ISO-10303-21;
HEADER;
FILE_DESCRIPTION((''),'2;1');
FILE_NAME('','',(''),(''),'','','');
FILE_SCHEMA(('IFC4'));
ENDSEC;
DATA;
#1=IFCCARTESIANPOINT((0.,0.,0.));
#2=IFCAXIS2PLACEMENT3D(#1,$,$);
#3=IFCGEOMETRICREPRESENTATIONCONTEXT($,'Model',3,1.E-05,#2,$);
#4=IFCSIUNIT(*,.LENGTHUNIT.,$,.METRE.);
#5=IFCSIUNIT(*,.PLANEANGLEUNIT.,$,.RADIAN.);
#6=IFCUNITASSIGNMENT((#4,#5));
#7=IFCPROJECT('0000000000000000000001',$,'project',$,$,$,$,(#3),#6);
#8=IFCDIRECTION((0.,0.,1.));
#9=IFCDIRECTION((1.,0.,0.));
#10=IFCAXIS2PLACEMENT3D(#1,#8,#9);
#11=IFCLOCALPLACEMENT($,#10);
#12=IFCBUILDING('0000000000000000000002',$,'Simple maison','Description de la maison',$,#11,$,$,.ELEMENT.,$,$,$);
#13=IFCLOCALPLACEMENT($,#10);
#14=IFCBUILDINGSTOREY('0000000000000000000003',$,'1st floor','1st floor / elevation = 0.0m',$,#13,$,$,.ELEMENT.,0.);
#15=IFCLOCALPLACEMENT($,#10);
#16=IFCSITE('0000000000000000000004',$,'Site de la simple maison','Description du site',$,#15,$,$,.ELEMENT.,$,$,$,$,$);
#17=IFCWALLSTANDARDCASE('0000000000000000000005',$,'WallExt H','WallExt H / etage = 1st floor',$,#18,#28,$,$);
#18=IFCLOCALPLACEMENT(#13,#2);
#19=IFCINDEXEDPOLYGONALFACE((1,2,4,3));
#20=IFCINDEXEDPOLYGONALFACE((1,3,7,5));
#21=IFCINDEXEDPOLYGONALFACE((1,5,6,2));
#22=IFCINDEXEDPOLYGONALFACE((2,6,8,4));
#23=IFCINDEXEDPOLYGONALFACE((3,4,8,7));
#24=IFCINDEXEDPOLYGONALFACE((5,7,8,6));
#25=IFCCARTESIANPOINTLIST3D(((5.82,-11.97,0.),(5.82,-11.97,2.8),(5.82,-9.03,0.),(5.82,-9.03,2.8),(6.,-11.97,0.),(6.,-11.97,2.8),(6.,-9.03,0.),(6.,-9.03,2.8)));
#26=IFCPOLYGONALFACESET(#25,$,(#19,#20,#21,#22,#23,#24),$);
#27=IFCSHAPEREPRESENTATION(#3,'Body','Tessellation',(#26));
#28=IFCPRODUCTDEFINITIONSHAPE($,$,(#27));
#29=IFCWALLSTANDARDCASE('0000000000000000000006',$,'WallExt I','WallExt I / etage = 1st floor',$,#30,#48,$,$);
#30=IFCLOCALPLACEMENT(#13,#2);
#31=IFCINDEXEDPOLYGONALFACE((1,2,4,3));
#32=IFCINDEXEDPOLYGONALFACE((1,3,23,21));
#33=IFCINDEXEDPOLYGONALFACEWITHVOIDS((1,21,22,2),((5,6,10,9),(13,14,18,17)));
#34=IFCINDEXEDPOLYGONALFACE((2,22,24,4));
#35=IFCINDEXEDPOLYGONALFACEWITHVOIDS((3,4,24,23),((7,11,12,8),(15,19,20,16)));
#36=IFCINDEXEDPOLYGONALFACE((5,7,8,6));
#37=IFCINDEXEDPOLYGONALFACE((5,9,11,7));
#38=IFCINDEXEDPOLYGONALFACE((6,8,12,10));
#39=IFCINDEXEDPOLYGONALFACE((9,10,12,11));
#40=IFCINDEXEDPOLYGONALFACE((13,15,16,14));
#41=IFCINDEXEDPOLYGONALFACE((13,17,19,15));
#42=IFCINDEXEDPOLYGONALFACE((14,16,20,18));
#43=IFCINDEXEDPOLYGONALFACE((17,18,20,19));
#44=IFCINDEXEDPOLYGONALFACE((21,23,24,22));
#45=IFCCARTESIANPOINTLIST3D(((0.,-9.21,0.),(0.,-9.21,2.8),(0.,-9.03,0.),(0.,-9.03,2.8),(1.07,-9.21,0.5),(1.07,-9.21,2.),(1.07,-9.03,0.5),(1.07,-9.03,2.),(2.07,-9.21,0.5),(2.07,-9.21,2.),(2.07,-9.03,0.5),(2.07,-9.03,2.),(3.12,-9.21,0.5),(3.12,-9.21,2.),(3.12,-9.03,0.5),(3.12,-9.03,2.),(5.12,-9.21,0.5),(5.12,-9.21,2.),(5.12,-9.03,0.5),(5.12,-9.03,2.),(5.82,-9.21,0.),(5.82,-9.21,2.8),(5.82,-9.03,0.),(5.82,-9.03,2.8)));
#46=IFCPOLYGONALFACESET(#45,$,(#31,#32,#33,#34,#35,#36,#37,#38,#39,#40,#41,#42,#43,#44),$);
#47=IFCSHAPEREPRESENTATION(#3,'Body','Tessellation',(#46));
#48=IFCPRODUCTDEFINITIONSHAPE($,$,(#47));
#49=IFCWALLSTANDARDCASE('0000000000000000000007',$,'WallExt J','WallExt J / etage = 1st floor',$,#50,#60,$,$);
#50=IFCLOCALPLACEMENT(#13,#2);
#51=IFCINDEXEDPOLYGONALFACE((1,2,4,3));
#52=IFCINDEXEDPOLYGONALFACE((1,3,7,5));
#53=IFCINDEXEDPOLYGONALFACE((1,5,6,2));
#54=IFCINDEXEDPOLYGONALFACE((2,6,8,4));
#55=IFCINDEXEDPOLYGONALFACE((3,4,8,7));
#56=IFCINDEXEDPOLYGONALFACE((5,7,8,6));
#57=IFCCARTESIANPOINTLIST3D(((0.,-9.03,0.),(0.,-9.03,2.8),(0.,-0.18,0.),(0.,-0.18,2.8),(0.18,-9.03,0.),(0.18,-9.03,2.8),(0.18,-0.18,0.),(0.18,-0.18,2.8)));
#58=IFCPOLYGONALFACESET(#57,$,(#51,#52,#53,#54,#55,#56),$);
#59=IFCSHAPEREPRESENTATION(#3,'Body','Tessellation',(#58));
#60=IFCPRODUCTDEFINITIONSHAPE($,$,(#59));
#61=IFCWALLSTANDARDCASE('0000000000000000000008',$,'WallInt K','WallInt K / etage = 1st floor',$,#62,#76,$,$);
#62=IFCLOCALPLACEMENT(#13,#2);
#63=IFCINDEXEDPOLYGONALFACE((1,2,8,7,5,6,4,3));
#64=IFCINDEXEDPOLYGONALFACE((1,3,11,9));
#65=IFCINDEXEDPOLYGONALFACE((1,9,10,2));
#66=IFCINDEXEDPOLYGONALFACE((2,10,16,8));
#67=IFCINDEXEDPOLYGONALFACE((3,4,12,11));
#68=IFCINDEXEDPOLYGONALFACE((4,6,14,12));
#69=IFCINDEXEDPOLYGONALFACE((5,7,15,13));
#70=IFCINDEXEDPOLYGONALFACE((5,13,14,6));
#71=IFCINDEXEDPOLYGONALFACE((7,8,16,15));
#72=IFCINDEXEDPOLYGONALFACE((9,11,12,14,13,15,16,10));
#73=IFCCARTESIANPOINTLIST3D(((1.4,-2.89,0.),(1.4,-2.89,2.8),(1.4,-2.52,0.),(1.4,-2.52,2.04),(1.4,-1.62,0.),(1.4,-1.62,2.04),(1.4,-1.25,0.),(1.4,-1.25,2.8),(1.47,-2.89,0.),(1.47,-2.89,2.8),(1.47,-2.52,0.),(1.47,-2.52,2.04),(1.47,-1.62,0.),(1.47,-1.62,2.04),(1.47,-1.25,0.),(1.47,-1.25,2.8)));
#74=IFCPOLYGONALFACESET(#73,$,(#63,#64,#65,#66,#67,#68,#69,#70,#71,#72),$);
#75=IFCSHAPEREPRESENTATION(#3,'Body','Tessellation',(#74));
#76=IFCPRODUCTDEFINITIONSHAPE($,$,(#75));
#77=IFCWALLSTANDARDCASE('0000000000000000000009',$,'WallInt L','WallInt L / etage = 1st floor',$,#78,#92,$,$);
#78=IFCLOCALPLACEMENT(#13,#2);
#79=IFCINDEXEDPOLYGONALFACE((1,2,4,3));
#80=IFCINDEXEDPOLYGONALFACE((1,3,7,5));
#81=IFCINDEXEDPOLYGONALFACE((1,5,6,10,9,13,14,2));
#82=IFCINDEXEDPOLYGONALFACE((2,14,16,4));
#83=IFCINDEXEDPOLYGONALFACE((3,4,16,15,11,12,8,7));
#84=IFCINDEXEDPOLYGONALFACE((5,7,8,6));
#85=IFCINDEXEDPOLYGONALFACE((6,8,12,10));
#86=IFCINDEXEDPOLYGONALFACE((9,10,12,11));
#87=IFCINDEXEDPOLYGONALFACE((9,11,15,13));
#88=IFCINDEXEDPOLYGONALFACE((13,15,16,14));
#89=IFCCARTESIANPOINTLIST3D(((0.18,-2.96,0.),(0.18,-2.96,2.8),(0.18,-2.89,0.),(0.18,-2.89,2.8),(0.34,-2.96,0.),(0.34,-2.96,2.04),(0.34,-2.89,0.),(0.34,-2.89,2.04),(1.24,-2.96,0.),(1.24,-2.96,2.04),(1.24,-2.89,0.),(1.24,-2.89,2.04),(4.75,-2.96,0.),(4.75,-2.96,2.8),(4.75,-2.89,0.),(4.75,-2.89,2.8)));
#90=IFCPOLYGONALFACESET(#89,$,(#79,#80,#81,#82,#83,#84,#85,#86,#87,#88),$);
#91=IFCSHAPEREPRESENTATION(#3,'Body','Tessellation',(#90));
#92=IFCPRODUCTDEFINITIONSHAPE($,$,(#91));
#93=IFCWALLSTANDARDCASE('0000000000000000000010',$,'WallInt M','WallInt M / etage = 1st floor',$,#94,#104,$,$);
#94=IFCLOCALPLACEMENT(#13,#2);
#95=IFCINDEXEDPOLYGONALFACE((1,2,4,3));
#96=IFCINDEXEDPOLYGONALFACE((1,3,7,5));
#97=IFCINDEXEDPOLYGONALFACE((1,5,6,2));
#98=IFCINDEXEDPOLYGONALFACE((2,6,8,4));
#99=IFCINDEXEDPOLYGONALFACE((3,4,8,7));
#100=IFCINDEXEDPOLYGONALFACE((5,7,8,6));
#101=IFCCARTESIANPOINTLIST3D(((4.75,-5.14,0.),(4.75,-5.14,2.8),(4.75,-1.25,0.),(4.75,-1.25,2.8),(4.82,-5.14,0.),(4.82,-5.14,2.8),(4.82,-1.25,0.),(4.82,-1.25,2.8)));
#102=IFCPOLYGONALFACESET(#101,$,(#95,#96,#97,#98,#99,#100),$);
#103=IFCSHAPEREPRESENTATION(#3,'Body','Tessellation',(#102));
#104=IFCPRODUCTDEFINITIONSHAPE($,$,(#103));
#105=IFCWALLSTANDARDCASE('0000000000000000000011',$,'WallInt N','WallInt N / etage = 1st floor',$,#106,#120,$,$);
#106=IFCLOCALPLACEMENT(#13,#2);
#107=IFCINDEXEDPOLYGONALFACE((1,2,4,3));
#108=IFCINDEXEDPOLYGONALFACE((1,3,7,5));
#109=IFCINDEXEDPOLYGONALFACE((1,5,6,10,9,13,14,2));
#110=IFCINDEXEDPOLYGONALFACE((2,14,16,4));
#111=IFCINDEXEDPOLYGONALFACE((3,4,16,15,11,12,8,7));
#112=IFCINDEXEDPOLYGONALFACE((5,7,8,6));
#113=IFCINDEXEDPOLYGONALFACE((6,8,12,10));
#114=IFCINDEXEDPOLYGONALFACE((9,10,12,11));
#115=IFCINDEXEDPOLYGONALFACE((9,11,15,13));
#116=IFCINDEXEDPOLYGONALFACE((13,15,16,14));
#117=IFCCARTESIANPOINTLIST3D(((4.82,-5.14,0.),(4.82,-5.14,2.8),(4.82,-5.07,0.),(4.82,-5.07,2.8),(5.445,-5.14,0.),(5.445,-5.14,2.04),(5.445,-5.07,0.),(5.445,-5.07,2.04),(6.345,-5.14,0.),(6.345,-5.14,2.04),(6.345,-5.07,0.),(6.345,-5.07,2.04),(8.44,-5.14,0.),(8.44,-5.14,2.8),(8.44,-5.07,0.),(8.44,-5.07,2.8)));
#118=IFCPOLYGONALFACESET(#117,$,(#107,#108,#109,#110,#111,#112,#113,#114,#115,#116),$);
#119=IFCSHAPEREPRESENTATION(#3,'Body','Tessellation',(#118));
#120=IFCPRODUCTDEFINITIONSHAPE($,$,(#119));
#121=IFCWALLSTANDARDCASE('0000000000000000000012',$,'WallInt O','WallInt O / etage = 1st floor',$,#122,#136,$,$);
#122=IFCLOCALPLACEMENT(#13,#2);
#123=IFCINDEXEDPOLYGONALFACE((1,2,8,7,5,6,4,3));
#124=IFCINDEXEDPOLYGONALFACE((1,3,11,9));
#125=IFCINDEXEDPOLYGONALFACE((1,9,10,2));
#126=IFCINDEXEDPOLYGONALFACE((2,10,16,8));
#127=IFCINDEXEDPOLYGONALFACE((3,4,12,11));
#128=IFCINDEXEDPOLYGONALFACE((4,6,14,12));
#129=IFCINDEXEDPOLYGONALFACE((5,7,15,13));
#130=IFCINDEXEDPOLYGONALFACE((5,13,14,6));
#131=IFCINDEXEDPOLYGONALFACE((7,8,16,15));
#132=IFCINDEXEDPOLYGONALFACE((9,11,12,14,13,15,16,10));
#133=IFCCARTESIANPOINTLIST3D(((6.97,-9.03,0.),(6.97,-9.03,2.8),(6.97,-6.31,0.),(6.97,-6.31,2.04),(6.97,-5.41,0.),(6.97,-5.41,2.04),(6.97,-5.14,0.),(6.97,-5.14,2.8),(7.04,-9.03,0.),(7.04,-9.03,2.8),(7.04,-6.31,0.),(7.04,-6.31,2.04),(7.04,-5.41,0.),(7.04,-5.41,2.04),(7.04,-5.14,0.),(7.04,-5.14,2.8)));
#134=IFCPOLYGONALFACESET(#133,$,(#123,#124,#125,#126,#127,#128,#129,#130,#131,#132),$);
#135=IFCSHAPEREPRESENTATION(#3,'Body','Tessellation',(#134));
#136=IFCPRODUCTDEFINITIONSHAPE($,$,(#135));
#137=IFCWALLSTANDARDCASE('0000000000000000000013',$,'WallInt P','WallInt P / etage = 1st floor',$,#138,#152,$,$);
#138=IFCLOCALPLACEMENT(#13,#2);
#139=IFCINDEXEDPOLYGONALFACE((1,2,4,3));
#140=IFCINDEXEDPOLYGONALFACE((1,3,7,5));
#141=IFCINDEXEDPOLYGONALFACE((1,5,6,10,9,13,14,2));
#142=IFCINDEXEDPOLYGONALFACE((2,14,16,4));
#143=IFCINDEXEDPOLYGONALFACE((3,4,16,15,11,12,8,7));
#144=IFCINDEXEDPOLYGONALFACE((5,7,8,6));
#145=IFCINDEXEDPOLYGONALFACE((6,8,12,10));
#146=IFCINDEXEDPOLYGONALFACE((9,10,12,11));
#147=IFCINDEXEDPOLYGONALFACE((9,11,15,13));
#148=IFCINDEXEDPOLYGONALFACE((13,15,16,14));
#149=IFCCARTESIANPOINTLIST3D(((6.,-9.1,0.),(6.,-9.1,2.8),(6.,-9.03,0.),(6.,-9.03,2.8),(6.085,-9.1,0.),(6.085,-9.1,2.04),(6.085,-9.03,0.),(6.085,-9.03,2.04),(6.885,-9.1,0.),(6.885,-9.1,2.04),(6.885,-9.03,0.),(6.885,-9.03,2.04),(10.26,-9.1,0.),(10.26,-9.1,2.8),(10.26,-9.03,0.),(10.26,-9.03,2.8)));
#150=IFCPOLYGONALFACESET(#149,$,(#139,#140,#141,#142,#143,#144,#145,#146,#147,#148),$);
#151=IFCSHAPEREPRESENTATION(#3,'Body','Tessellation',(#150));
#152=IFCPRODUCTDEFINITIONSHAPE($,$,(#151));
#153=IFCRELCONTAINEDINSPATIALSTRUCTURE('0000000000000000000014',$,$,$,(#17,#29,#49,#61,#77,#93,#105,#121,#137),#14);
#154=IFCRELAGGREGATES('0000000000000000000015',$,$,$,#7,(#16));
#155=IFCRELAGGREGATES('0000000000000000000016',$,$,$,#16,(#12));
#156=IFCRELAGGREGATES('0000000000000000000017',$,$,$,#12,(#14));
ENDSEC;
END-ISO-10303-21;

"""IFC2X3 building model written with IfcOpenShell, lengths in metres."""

from ifc_helpers import new_model, si_unit, frame, origin, origin_with_axes, origin_2d_with_axis, place, context, project, spatial, polyline, rectangle, outline, extrude, element, save


model = new_model("IFC2X3")

# Units and contexts
model_context = context("Model", 3, precision=1e-05, world=origin())
ifc_project = project(units=[si_unit("LENGTHUNIT", "METRE"), si_unit("PLANEANGLEUNIT", "RADIAN")], contexts=[model_context])

# Site, building, storey
site_placement = place(None, origin_with_axes())
site = spatial("IfcSite", under=ifc_project, at=site_placement, Name="Site de la simple maison", Description="Description du site", CompositionType="ELEMENT")
building_placement = place(None, origin_with_axes())
building = spatial("IfcBuilding", under=site, at=building_placement, Name="Simple maison", Description="Description de la maison", CompositionType="ELEMENT")
storey_placement = place(None, origin_with_axes())
storey = spatial("IfcBuildingStorey", under=building, at=storey_placement, Name="1st floor", Description="1st floor / elevation = 0.0m", CompositionType="ELEMENT", Elevation=0.0)

# Wall
wall_1_placement = place(storey_placement, frame((5.91, -11.97, 0.0), z_axis=(0.0, 0.0, 1.0), x_axis=(0.0, 1.0, 0.0)))
element("IfcWallStandardCase", 1, at=wall_1_placement, inside=storey, Name="WallExt H", Description="WallExt H / etage = 1st floor", context=model_context, shape_type="SweptSolid", body=[
    extrude(outline(polyline([(0.0, 0.09), (2.94, 0.09), (2.94, -0.09), (0.0, -0.09)])), origin(), (0.0, 0.0, 1.0), 2.8),
])

# Wall, openings
wall_2_placement = place(storey_placement, frame((5.82, -9.12, 0.0), z_axis=(0.0, 0.0, 1.0), x_axis=(-1.0, 0.0, 0.0)))
wall_2 = element("IfcWallStandardCase", 2, at=wall_2_placement, inside=storey, Name="WallExt I", Description="WallExt I / etage = 1st floor", context=model_context, shape_type="SweptSolid", body=[
    extrude(outline(polyline([(0.0, 0.09), (5.82, 0.09), (5.82, -0.09), (0.0, -0.09)])), origin(), (0.0, 0.0, 1.0), 2.8),
])
opening_1_placement = place(wall_2_placement, frame((3.75, -0.09, 0.5), z_axis=(0.0, 0.0, 1.0), x_axis=(1.0, 0.0, 0.0)))
element("IfcOpeningElement", 3, at=opening_1_placement, cuts=wall_2, context=model_context, shape_type="SweptSolid", body=[
    extrude(rectangle(XDim=1.5, YDim=1.0, at=origin_2d_with_axis()), frame((0.5, 0.0, 0.75), z_axis=(0.0, 1.0, 0.0), x_axis=(0.0, 0.0, 1.0)), (0.0, 0.0, 1.0), 0.18),
])
opening_2_placement = place(wall_2_placement, frame((0.7, -0.09, 0.5), z_axis=(0.0, 0.0, 1.0), x_axis=(1.0, 0.0, 0.0)))
element("IfcOpeningElement", 4, at=opening_2_placement, cuts=wall_2, context=model_context, shape_type="SweptSolid", body=[
    extrude(rectangle(XDim=1.5, YDim=2.0, at=origin_2d_with_axis()), frame((1.0, 0.0, 0.75), z_axis=(0.0, 1.0, 0.0), x_axis=(0.0, 0.0, 1.0)), (0.0, 0.0, 1.0), 0.18),
])

# Wall
wall_3_placement = place(storey_placement, frame((0.09, -9.03, 0.0), z_axis=(0.0, 0.0, 1.0), x_axis=(0.0, 1.0, 0.0)))
element("IfcWallStandardCase", 5, at=wall_3_placement, inside=storey, Name="WallExt J", Description="WallExt J / etage = 1st floor", context=model_context, shape_type="SweptSolid", body=[
    extrude(outline(polyline([(0.0, 0.09), (8.85, 0.09), (8.85, -0.09), (0.0, -0.09)])), origin(), (0.0, 0.0, 1.0), 2.8),
])

# Walls, openings
wall_4_placement = place(storey_placement, frame((1.435, -1.25, 0.0), z_axis=(0.0, 0.0, 1.0), x_axis=(0.0, -1.0, 0.0)))
wall_4 = element("IfcWallStandardCase", 6, at=wall_4_placement, inside=storey, Name="WallInt K", Description="WallInt K / etage = 1st floor", context=model_context, shape_type="SweptSolid", body=[
    extrude(outline(polyline([(0.0, 0.035), (1.64, 0.035), (1.64, -0.035), (0.0, -0.035)])), origin(), (0.0, 0.0, 1.0), 2.8),
])
opening_3_placement = place(wall_4_placement, frame((0.37, -0.035, 0.0), z_axis=(0.0, 0.0, 1.0), x_axis=(1.0, 0.0, 0.0)))
element("IfcOpeningElement", 7, at=opening_3_placement, cuts=wall_4, context=model_context, shape_type="SweptSolid", body=[
    extrude(rectangle(XDim=2.04, YDim=0.9, at=origin_2d_with_axis()), frame((0.45, 0.0, 1.02), z_axis=(0.0, 1.0, 0.0), x_axis=(0.0, 0.0, 1.0)), (0.0, 0.0, 1.0), 0.07),
])
wall_5_placement = place(storey_placement, frame((0.18, -2.925, 0.0), z_axis=(0.0, 0.0, 1.0), x_axis=(1.0, 0.0, 0.0)))
wall_5 = element("IfcWallStandardCase", 8, at=wall_5_placement, inside=storey, Name="WallInt L", Description="WallInt L / etage = 1st floor", context=model_context, shape_type="SweptSolid", body=[
    extrude(outline(polyline([(0.0, 0.035), (4.57, 0.035), (4.57, -0.035), (0.0, -0.035)])), origin(), (0.0, 0.0, 1.0), 2.8),
])
opening_4_placement = place(wall_5_placement, frame((0.16, -0.035, 0.0), z_axis=(0.0, 0.0, 1.0), x_axis=(1.0, 0.0, 0.0)))
element("IfcOpeningElement", 9, at=opening_4_placement, cuts=wall_5, context=model_context, shape_type="SweptSolid", body=[
    extrude(rectangle(XDim=2.04, YDim=0.9, at=origin_2d_with_axis()), frame((0.45, 0.0, 1.02), z_axis=(0.0, 1.0, 0.0), x_axis=(0.0, 0.0, 1.0)), (0.0, 0.0, 1.0), 0.07),
])

# Wall
wall_6_placement = place(storey_placement, frame((4.785, -1.25, 0.0), z_axis=(0.0, 0.0, 1.0), x_axis=(0.0, -1.0, 0.0)))
element("IfcWallStandardCase", 10, at=wall_6_placement, inside=storey, Name="WallInt M", Description="WallInt M / etage = 1st floor", context=model_context, shape_type="SweptSolid", body=[
    extrude(outline(polyline([(0.0, 0.035), (3.89, 0.035), (3.89, -0.035), (0.0, -0.035)])), origin(), (0.0, 0.0, 1.0), 2.8),
])

# Walls, openings
wall_7_placement = place(storey_placement, frame((4.82, -5.105, 0.0), z_axis=(0.0, 0.0, 1.0), x_axis=(1.0, 0.0, 0.0)))
wall_7 = element("IfcWallStandardCase", 11, at=wall_7_placement, inside=storey, Name="WallInt N", Description="WallInt N / etage = 1st floor", context=model_context, shape_type="SweptSolid", body=[
    extrude(outline(polyline([(0.0, 0.035), (3.62, 0.035), (3.62, -0.035), (0.0, -0.035)])), origin(), (0.0, 0.0, 1.0), 2.8),
])
opening_5_placement = place(wall_7_placement, frame((0.625, -0.035, 0.0), z_axis=(0.0, 0.0, 1.0), x_axis=(1.0, 0.0, 0.0)))
element("IfcOpeningElement", 12, at=opening_5_placement, cuts=wall_7, context=model_context, shape_type="SweptSolid", body=[
    extrude(rectangle(XDim=2.04, YDim=0.9, at=origin_2d_with_axis()), frame((0.45, 0.0, 1.02), z_axis=(0.0, 1.0, 0.0), x_axis=(0.0, 0.0, 1.0)), (0.0, 0.0, 1.0), 0.07),
])
wall_8_placement = place(storey_placement, frame((7.005, -5.14, 0.0), z_axis=(0.0, 0.0, 1.0), x_axis=(0.0, -1.0, 0.0)))
wall_8 = element("IfcWallStandardCase", 13, at=wall_8_placement, inside=storey, Name="WallInt O", Description="WallInt O / etage = 1st floor", context=model_context, shape_type="SweptSolid", body=[
    extrude(outline(polyline([(0.0, 0.035), (3.89, 0.035), (3.89, -0.035), (0.0, -0.035)])), origin(), (0.0, 0.0, 1.0), 2.8),
])
opening_6_placement = place(wall_8_placement, frame((0.27, -0.035, 0.0), z_axis=(0.0, 0.0, 1.0), x_axis=(1.0, 0.0, 0.0)))
element("IfcOpeningElement", 14, at=opening_6_placement, cuts=wall_8, context=model_context, shape_type="SweptSolid", body=[
    extrude(rectangle(XDim=2.04, YDim=0.9, at=origin_2d_with_axis()), frame((0.45, 0.0, 1.02), z_axis=(0.0, 1.0, 0.0), x_axis=(0.0, 0.0, 1.0)), (0.0, 0.0, 1.0), 0.07),
])
wall_9_placement = place(storey_placement, frame((6.0, -9.065, 0.0), z_axis=(0.0, 0.0, 1.0), x_axis=(1.0, 0.0, 0.0)))
wall_9 = element("IfcWallStandardCase", 15, at=wall_9_placement, inside=storey, Name="WallInt P", Description="WallInt P / etage = 1st floor", context=model_context, shape_type="SweptSolid", body=[
    extrude(outline(polyline([(0.0, 0.035), (4.26, 0.035), (4.26, -0.035), (0.0, -0.035)])), origin(), (0.0, 0.0, 1.0), 2.8),
])
opening_7_placement = place(wall_9_placement, frame((0.085, -0.035, 0.0), z_axis=(0.0, 0.0, 1.0), x_axis=(1.0, 0.0, 0.0)))
element("IfcOpeningElement", 16, at=opening_7_placement, cuts=wall_9, context=model_context, shape_type="SweptSolid", body=[
    extrude(rectangle(XDim=2.04, YDim=0.8, at=origin_2d_with_axis()), frame((0.4, 0.0, 1.02), z_axis=(0.0, 1.0, 0.0), x_axis=(0.0, 0.0, 1.0)), (0.0, 0.0, 1.0), 0.07),
])

save(model, "model.ifc")
